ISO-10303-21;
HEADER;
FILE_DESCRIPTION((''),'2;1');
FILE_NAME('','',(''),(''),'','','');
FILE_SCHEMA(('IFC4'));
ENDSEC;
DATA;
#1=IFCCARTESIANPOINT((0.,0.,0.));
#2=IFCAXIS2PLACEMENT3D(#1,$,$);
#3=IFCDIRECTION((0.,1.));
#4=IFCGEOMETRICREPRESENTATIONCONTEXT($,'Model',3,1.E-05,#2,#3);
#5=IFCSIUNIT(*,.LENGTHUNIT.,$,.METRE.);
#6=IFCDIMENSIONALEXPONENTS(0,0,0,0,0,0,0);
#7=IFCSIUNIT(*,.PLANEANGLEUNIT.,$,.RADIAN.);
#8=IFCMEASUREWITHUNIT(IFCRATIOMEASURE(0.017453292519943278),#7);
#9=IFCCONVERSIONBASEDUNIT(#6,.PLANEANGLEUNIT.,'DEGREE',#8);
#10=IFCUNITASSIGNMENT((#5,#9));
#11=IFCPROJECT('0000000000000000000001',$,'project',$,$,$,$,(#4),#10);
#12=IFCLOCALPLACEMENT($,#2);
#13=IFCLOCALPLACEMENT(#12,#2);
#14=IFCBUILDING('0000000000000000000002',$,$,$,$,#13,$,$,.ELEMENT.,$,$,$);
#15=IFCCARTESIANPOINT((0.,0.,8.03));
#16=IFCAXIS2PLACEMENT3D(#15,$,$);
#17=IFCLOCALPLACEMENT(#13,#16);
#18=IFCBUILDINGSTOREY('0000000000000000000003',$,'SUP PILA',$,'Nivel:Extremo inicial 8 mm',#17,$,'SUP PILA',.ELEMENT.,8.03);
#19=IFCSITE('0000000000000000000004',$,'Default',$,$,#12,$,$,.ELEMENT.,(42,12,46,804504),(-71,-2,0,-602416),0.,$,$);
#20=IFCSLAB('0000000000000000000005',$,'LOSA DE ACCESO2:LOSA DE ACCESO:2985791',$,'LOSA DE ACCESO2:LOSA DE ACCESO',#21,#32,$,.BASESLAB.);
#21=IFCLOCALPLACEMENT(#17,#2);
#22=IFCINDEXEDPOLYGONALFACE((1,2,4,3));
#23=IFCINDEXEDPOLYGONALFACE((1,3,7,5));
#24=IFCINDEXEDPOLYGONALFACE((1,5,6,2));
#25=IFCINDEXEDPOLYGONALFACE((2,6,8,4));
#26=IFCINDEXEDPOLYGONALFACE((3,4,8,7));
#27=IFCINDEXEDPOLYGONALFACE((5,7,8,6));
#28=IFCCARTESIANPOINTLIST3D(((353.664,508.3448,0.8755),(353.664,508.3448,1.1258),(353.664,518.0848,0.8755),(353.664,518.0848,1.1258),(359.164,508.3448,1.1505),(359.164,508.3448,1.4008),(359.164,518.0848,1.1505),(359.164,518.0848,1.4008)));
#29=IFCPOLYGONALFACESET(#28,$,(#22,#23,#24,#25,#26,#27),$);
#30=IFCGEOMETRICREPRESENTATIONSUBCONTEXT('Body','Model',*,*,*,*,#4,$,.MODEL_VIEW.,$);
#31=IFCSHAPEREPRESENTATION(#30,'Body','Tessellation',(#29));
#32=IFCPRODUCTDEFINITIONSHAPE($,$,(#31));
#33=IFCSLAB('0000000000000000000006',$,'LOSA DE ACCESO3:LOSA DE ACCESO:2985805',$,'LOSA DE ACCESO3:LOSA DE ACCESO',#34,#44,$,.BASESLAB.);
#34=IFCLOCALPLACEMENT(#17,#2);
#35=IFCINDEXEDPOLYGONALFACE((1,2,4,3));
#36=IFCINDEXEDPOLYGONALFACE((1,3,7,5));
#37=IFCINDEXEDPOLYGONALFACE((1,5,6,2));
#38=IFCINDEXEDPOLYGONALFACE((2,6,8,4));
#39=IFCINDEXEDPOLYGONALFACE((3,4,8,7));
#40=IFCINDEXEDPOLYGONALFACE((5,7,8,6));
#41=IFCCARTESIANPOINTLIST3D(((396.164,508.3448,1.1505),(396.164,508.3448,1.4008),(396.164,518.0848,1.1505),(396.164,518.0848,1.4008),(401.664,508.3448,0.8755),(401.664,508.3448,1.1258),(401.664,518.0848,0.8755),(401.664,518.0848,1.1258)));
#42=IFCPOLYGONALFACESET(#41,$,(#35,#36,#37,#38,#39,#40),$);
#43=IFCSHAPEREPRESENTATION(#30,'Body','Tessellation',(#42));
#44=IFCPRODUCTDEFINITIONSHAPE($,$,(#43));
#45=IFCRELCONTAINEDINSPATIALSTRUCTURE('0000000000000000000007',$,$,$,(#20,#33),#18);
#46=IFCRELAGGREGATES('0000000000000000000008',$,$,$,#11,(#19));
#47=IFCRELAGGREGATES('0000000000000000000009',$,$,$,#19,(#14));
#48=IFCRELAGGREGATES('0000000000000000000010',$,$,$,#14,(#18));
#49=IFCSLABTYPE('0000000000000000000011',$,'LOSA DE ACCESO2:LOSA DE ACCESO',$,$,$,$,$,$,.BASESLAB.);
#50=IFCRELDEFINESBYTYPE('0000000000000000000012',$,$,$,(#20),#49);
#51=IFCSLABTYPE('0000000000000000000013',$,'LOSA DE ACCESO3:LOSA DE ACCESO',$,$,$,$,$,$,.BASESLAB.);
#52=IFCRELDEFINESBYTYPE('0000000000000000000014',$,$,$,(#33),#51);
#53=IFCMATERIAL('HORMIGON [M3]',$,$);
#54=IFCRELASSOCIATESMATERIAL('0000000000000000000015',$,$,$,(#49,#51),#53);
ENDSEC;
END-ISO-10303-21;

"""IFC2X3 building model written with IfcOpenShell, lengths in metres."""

from ifc_helpers import new_model, entity, si_unit, converted_unit, direction, frame, origin, place, context, subcontext, project, spatial, polyline, outline, extrude, material, type_object, element, save


model = new_model("IFC2X3")

# Units and contexts
model_context = context("Model", 3, precision=1e-05, world=origin(), true_north=direction((0.0, 1.0)))
body_context = subcontext(model_context, "Body", "Model", "MODEL_VIEW")
ifc_project = project(units=[si_unit("LENGTHUNIT", "METRE"), converted_unit("PLANEANGLEUNIT", "DEGREE", entity("IfcRatioMeasure", 0.017453292519943278), si_unit("PLANEANGLEUNIT", "RADIAN"), dimensions=[0, 0, 0, 0, 0, 0, 0])], contexts=[model_context])

# Site, building, storey
site_placement = place(None, origin())
site = spatial("IfcSite", under=ifc_project, at=site_placement, Name="Default", CompositionType="ELEMENT", RefLatitude=(42, 12, 46, 804504), RefLongitude=(-71, -2, 0, -602416), RefElevation=0.0)
building_placement = place(site_placement, origin())
building = spatial("IfcBuilding", under=site, at=building_placement, CompositionType="ELEMENT")
storey_placement = place(building_placement, frame((0.0, 0.0, 8.03)))
storey = spatial("IfcBuildingStorey", under=building, at=storey_placement, Name="SUP PILA", ObjectType="Nivel:Extremo inicial 8 mm", LongName="SUP PILA", CompositionType="ELEMENT", Elevation=8.03)

# Slabs
ifc_material_1 = material(Name="HORMIGON [M3]")
slab_type_1 = type_object("IfcSlabType", Name="LOSA DE ACCESO2:LOSA DE ACCESO", PredefinedType="BASESLAB", material=ifc_material_1)
slab_1_placement = place(storey_placement, origin())
element("IfcSlab", 1, at=slab_1_placement, inside=storey, type_object=slab_type_1, Name="LOSA DE ACCESO2:LOSA DE ACCESO:2985791", ObjectType="LOSA DE ACCESO2:LOSA DE ACCESO", PredefinedType="BASESLAB", context=body_context, shape_type="SweptSolid", body=[
    extrude(outline(polyline([(-2.7472, -0.125), (2.7597, -0.125), (2.7472, 0.125), (-2.7597, 0.125), (-2.7472, -0.125)])), frame((356.414, 508.3448, 1.1381), z_axis=(0.0, 1.0, 0.0), x_axis=(-0.998752, 0.0, -0.049938)), (0.0, 0.0, 1.0), 9.74),
])
slab_type_2 = type_object("IfcSlabType", Name="LOSA DE ACCESO3:LOSA DE ACCESO", PredefinedType="BASESLAB", material=ifc_material_1)
slab_2_placement = place(storey_placement, origin())
element("IfcSlab", 2, at=slab_2_placement, inside=storey, type_object=slab_type_2, Name="LOSA DE ACCESO3:LOSA DE ACCESO:2985805", ObjectType="LOSA DE ACCESO3:LOSA DE ACCESO", PredefinedType="BASESLAB", context=body_context, shape_type="SweptSolid", body=[
    extrude(outline(polyline([(0.0123, -2.75), (0.2627, -2.75), (-0.0123, 2.75), (-0.2627, 2.75), (0.0123, -2.75)])), frame((398.914, 508.3448, 1.1381), z_axis=(0.0, 1.0, 0.0), x_axis=(0.0, 0.0, 1.0)), (0.0, 0.0, 1.0), 9.74),
])

save(model, "model.ifc")
